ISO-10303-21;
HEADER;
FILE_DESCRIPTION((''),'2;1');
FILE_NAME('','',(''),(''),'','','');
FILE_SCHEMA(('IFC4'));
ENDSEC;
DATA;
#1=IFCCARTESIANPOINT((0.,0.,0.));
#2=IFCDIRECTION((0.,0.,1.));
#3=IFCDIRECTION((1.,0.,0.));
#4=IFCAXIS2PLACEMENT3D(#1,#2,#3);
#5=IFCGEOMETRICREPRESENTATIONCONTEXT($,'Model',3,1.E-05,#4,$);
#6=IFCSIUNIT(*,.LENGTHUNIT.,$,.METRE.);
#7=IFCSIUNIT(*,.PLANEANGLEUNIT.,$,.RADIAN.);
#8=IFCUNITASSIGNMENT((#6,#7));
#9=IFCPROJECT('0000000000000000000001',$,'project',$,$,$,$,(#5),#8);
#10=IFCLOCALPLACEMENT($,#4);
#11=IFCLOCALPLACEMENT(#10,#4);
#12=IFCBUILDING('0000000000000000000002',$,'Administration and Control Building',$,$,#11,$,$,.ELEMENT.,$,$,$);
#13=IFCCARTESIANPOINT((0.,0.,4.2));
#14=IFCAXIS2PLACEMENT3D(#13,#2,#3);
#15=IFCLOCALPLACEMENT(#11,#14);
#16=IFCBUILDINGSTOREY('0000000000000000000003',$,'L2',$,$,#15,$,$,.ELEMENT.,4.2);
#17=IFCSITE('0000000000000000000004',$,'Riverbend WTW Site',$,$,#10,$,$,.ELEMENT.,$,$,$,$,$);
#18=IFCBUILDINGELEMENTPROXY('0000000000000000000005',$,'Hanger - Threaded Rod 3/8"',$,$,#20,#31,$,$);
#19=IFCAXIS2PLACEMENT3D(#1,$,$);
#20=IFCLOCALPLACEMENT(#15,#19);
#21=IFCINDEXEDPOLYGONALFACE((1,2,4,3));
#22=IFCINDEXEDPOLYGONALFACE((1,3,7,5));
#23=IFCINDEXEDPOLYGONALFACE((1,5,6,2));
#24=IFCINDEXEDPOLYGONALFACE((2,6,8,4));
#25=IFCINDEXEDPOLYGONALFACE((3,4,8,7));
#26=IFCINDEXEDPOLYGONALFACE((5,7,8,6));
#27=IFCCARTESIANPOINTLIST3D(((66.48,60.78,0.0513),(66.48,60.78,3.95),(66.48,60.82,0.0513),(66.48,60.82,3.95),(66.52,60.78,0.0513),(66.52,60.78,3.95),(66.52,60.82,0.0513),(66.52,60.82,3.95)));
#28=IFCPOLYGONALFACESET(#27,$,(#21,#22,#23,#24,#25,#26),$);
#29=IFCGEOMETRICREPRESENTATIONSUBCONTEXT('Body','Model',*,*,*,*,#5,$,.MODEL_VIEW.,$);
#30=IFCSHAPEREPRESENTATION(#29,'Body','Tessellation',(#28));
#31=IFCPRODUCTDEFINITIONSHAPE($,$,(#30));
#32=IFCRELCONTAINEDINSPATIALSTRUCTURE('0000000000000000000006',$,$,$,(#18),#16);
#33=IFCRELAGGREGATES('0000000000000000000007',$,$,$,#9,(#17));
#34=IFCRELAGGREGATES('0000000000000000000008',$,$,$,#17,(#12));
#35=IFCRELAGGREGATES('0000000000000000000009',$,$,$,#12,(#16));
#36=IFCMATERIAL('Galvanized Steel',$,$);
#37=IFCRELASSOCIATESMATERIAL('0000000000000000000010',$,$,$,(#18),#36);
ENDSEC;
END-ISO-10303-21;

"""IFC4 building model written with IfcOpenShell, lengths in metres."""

from ifc_helpers import new_model, si_unit, frame, origin_with_axes, origin_2d, place, context, subcontext, project, spatial, rectangle, extrude, material, element, save


model = new_model("IFC4")

# Units and contexts
model_context = context("Model", 3, precision=1e-05, world=origin_with_axes())
body_context = subcontext(model_context, "Body", "Model", "MODEL_VIEW")
ifc_project = project(units=[si_unit("LENGTHUNIT", "METRE"), si_unit("PLANEANGLEUNIT", "RADIAN")], contexts=[model_context])

# Site, building, storey
site_placement = place(None, origin_with_axes())
site = spatial("IfcSite", under=ifc_project, at=site_placement, Name="Riverbend WTW Site", CompositionType="ELEMENT")
building_placement = place(site_placement, origin_with_axes())
building = spatial("IfcBuilding", under=site, at=building_placement, Name="Administration and Control Building", CompositionType="ELEMENT")
storey_placement = place(building_placement, frame((0.0, 0.0, 4.2), z_axis=(0.0, 0.0, 1.0), x_axis=(1.0, 0.0, 0.0)))
storey = spatial("IfcBuildingStorey", under=building, at=storey_placement, Name="L2", CompositionType="ELEMENT", Elevation=4.2)

# Shared definitions
ifc_material_1 = material(Name="Galvanized Steel")

# Building element proxy
proxy_placement = place(None, frame((66.5, 60.8, 6.2006), z_axis=(0.0, 0.0, 1.0), x_axis=(1.0, 0.0, 0.0)))
element("IfcBuildingElementProxy", 1, at=proxy_placement, inside=storey, material=ifc_material_1, Name="Hanger - Threaded Rod 3/8\"", context=body_context, shape_type="SweptSolid", body=[
    extrude(rectangle(XDim=0.04, YDim=0.04, at=origin_2d()), frame((0.0, 0.0, -1.9494), z_axis=(0.0, 0.0, 1.0), x_axis=(1.0, 0.0, 0.0)), (0.0, 0.0, 1.0), 3.8988),
])

save(model, "model.ifc")
